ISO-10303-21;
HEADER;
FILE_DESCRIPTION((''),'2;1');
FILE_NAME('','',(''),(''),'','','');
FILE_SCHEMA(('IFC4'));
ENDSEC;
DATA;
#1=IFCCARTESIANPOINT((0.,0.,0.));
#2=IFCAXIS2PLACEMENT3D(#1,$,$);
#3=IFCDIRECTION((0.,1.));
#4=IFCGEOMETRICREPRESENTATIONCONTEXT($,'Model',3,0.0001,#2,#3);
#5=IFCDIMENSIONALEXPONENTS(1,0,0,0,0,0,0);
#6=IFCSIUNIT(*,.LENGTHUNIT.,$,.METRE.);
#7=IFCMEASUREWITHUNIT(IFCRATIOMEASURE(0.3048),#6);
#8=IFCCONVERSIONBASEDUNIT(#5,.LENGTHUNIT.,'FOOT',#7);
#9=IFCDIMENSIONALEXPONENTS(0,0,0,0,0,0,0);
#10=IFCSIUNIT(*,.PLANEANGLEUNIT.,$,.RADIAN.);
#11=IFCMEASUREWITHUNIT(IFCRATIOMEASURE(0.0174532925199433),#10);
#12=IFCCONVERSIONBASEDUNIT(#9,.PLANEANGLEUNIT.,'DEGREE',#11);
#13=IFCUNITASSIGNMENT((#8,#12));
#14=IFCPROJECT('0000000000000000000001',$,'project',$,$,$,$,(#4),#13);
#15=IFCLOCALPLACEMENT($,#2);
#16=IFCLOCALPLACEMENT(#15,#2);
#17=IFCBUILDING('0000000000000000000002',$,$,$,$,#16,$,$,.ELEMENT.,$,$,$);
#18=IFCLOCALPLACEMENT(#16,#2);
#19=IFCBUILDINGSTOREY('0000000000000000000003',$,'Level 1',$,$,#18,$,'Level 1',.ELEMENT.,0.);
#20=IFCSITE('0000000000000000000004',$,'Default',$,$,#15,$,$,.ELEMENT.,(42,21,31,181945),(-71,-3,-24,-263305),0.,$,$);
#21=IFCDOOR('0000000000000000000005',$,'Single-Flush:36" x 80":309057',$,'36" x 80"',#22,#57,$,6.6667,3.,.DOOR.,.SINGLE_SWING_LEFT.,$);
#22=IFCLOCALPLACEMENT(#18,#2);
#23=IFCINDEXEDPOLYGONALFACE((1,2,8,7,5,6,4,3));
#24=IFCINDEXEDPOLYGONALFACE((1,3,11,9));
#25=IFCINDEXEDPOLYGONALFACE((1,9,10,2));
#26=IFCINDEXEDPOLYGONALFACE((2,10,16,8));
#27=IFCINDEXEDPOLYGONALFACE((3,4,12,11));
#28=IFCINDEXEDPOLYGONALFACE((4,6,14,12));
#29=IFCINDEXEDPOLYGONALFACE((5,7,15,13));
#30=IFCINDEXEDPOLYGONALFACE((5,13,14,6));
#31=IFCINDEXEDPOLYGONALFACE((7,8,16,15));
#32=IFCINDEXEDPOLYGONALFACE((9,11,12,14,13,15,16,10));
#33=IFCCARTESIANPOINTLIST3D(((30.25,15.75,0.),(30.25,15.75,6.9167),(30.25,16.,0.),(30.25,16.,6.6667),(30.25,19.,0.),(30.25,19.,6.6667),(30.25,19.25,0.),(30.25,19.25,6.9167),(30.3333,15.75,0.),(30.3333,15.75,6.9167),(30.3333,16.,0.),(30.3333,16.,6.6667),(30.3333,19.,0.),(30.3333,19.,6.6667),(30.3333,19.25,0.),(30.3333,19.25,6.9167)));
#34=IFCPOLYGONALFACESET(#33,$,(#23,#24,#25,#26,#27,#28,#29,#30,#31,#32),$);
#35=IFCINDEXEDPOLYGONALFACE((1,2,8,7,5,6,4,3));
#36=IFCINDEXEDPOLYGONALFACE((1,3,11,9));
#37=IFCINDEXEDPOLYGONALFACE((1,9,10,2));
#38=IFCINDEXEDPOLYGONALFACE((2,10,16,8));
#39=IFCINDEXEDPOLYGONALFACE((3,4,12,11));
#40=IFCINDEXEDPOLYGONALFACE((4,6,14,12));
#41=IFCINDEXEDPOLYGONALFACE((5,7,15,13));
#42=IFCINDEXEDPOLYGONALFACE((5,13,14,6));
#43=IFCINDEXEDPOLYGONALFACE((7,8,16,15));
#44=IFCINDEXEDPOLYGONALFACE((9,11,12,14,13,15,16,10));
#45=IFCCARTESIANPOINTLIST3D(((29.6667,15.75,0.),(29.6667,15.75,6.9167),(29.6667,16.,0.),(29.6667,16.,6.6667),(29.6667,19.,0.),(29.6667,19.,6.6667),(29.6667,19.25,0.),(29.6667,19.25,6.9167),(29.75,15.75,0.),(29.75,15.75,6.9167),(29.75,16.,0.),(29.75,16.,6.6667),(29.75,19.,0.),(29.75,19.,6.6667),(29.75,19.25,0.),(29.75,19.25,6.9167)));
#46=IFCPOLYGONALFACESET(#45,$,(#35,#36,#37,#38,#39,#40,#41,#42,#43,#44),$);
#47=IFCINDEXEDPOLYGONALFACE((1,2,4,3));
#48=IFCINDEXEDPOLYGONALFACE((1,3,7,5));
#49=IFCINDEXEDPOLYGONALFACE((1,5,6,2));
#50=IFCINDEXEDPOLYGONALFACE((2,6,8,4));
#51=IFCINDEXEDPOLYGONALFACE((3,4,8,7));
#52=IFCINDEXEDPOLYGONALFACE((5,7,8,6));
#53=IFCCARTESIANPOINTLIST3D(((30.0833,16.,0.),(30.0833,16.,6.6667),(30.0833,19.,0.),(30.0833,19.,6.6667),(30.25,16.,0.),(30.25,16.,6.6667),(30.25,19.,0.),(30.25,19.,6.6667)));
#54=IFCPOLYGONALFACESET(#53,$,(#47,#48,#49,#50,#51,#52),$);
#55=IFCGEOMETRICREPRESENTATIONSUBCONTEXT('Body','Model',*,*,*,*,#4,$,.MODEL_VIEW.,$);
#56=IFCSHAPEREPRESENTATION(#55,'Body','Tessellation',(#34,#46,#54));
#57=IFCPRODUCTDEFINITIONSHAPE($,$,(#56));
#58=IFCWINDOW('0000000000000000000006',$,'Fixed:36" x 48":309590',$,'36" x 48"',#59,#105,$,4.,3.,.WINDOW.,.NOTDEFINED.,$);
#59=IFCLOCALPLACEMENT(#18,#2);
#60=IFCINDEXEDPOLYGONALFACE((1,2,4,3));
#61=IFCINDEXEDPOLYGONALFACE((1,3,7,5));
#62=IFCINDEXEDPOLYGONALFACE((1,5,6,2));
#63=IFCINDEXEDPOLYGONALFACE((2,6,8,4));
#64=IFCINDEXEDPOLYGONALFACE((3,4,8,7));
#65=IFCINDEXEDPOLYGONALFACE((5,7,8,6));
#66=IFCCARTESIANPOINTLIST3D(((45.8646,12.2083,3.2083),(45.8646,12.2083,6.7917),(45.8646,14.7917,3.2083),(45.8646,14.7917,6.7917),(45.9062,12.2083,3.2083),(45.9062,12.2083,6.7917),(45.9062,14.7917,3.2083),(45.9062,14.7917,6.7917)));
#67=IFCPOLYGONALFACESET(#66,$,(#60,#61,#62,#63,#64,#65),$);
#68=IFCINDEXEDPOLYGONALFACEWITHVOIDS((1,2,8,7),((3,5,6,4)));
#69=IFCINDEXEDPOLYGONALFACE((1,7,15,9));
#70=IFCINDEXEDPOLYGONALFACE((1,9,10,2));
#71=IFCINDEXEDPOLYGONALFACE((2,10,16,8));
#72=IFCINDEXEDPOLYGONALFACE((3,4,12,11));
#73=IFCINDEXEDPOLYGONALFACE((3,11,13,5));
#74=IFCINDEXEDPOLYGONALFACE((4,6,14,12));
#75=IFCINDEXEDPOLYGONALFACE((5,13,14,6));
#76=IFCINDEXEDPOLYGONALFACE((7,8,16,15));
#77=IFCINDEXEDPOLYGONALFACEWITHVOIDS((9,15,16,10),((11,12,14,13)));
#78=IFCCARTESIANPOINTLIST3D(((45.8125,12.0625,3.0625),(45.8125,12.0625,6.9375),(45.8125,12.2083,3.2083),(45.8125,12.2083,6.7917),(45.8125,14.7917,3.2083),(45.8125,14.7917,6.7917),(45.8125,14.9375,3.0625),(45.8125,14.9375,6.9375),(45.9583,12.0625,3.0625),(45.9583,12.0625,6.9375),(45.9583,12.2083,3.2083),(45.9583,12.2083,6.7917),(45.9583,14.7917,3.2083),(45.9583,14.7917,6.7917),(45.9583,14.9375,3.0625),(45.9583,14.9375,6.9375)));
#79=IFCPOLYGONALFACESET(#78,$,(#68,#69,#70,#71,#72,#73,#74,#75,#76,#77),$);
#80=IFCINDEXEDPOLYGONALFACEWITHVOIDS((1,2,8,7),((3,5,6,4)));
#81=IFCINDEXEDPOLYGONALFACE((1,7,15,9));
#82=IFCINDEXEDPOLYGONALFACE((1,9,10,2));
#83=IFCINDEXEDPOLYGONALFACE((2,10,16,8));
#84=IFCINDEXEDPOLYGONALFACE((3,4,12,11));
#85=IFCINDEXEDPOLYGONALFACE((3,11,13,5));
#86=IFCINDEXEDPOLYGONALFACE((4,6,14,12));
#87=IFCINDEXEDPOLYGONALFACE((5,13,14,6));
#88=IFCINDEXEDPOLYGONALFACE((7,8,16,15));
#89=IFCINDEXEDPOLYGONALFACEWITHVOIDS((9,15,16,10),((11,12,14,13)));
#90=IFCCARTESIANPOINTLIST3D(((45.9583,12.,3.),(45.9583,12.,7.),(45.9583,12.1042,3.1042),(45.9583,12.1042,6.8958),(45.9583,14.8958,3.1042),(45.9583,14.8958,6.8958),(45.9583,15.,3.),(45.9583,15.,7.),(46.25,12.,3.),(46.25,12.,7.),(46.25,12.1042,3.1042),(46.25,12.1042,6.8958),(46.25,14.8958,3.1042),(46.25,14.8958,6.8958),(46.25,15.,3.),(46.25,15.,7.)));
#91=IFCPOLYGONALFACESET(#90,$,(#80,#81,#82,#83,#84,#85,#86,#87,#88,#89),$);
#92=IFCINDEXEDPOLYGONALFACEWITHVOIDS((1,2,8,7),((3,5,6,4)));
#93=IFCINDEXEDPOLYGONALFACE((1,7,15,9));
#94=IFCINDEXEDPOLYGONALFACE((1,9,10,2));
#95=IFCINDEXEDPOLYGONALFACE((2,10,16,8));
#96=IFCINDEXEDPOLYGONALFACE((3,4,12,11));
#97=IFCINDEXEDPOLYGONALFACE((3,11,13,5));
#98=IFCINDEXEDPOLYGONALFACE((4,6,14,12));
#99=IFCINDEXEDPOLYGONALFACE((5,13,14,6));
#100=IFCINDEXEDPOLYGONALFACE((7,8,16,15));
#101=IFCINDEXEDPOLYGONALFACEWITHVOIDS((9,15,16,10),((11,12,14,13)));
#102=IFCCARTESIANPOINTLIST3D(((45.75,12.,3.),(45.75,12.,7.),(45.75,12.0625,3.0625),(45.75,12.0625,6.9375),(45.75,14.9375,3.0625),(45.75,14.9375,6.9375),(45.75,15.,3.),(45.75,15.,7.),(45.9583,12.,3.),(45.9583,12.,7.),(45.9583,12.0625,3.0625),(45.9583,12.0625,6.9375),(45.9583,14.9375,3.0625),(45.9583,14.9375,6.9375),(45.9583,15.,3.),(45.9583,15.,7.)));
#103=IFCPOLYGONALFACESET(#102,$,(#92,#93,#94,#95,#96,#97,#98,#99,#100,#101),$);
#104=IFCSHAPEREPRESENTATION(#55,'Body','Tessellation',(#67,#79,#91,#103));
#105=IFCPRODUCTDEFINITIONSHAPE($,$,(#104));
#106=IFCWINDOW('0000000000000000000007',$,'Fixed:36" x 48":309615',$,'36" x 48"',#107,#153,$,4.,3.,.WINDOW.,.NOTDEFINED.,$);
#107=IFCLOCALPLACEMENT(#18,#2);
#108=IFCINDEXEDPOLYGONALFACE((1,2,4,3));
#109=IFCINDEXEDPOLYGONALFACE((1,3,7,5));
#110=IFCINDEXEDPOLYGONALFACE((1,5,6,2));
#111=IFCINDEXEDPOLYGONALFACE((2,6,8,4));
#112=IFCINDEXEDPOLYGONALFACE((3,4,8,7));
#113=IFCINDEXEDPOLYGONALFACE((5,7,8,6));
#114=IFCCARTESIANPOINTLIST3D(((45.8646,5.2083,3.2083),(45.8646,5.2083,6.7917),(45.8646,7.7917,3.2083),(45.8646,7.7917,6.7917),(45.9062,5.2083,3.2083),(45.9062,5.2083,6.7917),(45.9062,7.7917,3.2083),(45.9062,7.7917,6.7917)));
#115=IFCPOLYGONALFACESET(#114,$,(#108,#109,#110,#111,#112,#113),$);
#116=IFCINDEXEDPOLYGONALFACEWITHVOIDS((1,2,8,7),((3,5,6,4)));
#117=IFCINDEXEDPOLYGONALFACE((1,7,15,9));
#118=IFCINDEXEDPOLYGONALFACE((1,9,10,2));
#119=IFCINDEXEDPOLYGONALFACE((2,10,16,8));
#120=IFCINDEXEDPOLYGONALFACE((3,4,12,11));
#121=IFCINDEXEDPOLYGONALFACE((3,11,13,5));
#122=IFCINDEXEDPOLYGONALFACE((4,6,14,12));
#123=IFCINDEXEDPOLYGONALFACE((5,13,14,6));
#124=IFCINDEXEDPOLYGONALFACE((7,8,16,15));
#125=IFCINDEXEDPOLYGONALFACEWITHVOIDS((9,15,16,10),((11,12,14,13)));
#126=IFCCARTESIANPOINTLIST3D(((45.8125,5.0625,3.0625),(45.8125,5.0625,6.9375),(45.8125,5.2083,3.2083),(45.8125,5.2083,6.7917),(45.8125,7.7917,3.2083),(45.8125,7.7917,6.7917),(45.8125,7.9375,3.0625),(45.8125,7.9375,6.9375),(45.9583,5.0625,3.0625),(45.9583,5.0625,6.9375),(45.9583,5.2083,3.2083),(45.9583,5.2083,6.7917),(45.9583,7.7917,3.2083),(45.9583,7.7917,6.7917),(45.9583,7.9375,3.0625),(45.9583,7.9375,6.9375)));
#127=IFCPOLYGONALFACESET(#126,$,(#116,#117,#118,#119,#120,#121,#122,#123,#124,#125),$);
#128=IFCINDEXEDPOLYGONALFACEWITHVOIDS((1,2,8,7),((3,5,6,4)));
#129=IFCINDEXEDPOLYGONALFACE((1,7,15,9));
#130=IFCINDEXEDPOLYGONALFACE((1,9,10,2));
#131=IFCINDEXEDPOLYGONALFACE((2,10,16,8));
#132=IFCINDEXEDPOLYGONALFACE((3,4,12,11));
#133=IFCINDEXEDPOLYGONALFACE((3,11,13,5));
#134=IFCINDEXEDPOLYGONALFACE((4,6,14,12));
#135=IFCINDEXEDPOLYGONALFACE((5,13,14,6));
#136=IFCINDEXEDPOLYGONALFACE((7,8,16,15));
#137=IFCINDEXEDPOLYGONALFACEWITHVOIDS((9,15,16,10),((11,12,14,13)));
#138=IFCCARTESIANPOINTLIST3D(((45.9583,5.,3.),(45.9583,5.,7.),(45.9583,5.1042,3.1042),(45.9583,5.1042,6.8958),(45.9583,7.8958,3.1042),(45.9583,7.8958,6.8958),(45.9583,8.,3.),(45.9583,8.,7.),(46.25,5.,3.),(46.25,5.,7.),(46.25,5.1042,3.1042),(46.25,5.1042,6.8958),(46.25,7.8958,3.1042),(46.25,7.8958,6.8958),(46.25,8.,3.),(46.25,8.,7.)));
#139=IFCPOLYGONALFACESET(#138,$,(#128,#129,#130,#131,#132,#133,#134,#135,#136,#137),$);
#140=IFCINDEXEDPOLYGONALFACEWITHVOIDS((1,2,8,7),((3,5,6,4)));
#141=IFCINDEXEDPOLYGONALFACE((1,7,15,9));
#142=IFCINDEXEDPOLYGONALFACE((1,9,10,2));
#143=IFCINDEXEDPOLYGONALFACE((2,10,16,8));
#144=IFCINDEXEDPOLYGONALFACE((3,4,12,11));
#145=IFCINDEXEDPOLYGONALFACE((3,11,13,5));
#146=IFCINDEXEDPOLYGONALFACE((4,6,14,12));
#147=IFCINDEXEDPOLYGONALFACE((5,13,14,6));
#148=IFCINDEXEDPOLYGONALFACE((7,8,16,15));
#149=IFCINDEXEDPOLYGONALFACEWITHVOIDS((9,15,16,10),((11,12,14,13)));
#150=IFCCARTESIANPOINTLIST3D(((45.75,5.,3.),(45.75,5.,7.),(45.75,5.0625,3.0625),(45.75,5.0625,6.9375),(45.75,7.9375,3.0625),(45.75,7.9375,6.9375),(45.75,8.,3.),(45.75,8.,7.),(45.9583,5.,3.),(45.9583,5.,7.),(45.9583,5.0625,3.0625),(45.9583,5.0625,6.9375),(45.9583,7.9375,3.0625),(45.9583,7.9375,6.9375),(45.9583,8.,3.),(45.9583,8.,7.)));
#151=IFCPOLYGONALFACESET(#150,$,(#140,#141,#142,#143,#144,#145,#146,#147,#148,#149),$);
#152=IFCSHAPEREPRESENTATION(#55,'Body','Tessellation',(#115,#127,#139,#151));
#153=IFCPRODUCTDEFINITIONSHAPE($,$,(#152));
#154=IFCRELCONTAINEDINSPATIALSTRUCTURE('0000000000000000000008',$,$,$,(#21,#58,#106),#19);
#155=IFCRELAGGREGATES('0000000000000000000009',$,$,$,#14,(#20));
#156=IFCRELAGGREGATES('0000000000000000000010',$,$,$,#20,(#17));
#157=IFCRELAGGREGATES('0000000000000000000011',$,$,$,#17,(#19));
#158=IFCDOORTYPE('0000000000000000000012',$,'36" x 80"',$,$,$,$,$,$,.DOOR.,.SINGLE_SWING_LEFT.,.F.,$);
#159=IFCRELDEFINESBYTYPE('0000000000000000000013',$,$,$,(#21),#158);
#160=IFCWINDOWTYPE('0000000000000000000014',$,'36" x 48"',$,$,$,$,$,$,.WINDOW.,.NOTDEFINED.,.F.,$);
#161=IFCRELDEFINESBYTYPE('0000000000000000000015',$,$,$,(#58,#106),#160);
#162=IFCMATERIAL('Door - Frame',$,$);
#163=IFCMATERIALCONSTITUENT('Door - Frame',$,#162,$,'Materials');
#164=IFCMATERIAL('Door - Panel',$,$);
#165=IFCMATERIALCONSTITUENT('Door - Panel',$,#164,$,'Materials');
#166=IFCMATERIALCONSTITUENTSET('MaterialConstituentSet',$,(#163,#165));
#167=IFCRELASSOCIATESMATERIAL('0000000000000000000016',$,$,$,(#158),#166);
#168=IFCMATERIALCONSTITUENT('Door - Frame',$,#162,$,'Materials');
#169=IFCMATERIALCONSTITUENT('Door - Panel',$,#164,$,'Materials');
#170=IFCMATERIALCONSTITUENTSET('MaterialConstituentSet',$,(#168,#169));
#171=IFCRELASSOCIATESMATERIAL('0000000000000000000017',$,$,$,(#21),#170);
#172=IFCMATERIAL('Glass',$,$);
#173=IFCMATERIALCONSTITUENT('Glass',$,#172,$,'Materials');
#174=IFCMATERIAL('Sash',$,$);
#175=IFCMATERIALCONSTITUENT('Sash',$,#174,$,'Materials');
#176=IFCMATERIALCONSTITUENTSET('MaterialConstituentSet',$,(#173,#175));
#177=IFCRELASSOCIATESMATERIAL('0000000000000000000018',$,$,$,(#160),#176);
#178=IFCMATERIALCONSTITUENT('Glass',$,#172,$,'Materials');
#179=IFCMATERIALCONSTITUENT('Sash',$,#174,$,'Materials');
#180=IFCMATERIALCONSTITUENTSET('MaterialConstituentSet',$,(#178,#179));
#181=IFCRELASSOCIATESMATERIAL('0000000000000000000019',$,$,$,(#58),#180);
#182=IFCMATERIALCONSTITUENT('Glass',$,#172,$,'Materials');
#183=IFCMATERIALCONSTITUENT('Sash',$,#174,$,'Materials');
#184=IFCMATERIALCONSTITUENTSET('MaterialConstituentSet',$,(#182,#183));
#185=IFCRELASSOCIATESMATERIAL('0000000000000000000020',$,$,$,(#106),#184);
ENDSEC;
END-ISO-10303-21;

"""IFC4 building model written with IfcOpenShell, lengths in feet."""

from ifc_helpers import new_model, entity, si_unit, converted_unit, direction, frame, frame_2d, origin, origin_2d_with_axis, place, context, subcontext, project, spatial, polyline, rectangle, outline, extrude, source, transform, mapped, material, constituent, constituent_set, type_object, type_shapes, element, save


model = new_model("IFC4")

# Units and contexts
model_context = context("Model", 3, precision=0.0001, world=origin(), true_north=direction((0.0, 1.0)))
body_context = subcontext(model_context, "Body", "Model", "MODEL_VIEW")
ifc_project = project(units=[converted_unit("LENGTHUNIT", "FOOT", entity("IfcRatioMeasure", 0.3048), si_unit("LENGTHUNIT", "METRE"), dimensions=[1, 0, 0, 0, 0, 0, 0]), converted_unit("PLANEANGLEUNIT", "DEGREE", entity("IfcRatioMeasure", 0.0174532925199433), si_unit("PLANEANGLEUNIT", "RADIAN"), dimensions=[0, 0, 0, 0, 0, 0, 0])], contexts=[model_context])

# Site, building, storey
site_placement = place(None, origin())
site = spatial("IfcSite", under=ifc_project, at=site_placement, Name="Default", CompositionType="ELEMENT", RefLatitude=(42, 21, 31, 181945), RefLongitude=(-71, -3, -24, -263305), RefElevation=0.0)
building_placement = place(site_placement, origin())
building = spatial("IfcBuilding", under=site, at=building_placement, CompositionType="ELEMENT")
storey_placement = place(building_placement, origin())
storey = spatial("IfcBuildingStorey", under=building, at=storey_placement, Name="Level 1", LongName="Level 1", CompositionType="ELEMENT", Elevation=0.0)

# Door
ifc_material_1 = material(Name="Door - Frame")
ifc_material_2 = material(Name="Door - Panel")
ifc_constituent_1 = constituent(ifc_material_1, Name="Door - Frame", Category="Materials")
ifc_constituent_2 = constituent(ifc_material_2, Name="Door - Panel", Category="Materials")
ifc_constituent_set_1 = constituent_set(constituents=[ifc_constituent_1, ifc_constituent_2], Name="MaterialConstituentSet")
ifc_constituent_3 = constituent(ifc_material_1, Name="Door - Frame", Category="Materials")
ifc_constituent_4 = constituent(ifc_material_2, Name="Door - Panel", Category="Materials")
ifc_constituent_set_2 = constituent_set(constituents=[ifc_constituent_3, ifc_constituent_4], Name="MaterialConstituentSet")
door_type_1 = type_object("IfcDoorType", Name="36\" x 80\"", OperationType="SINGLE_SWING_LEFT", ParameterTakesPrecedence=False, PredefinedType="DOOR", material=ifc_constituent_set_2)
shared_shape_1 = source(origin(), body_context, "Body", "SweptSolid", [
    extrude(outline(polyline([(-1.75, -3.5208), (1.75, -3.5208), (1.75, 3.3958), (1.5, 3.3958), (1.5, -3.2708), (-1.5, -3.2708), (-1.5, 3.3958), (-1.75, 3.3958), (-1.75, -3.5208)])), frame((1.5, 0.5833, 3.3958), z_axis=(0.0, -1.0, 0.0), x_axis=(-1.0, 0.0, 0.0)), (0.0, 0.0, 1.0), 0.0833),
    extrude(outline(polyline([(-3.5208, -1.75), (3.3958, -1.75), (3.3958, -1.5), (-3.2708, -1.5), (-3.2708, 1.5), (3.3958, 1.5), (3.3958, 1.75), (-3.5208, 1.75), (-3.5208, -1.75)])), frame((1.5, 0.0, 3.3958), z_axis=(0.0, -1.0, 0.0), x_axis=(0.0, 0.0, -1.0)), (0.0, 0.0, 1.0), 0.0833),
    extrude(rectangle(XDim=3.0, YDim=0.1667, at=origin_2d_with_axis()), frame((1.5, 0.4167, 0.0)), (0.0, 0.0, 1.0), 6.6667),
])
type_shapes(door_type_1, [shared_shape_1])
placement_1 = place(storey_placement, frame((30.0, 45.75, 0.0), z_axis=(0.0, 0.0, 1.0), x_axis=(0.0, -1.0, 0.0)))
placement_2 = place(placement_1, frame((26.75, -0.25, 0.0)))
door_1_placement = place(placement_2, origin())
element("IfcDoor", 1, at=door_1_placement, inside=storey, type_object=door_type_1, material=ifc_constituent_set_1, Name="Single-Flush:36\" x 80\":309057", ObjectType="36\" x 80\"", OperationType="SINGLE_SWING_LEFT", OverallHeight=6.6667, OverallWidth=3.0, PredefinedType="DOOR", context=body_context, shape_type="MappedRepresentation", body=[
    mapped(shared_shape_1, transform((0.0, 0.0, 0.0), scale=1.0)),
])

# Windows
ifc_material_3 = material(Name="Glass")
ifc_constituent_5 = constituent(ifc_material_3, Name="Glass", Category="Materials")
ifc_material_4 = material(Name="Sash")
ifc_constituent_6 = constituent(ifc_material_4, Name="Sash", Category="Materials")
ifc_constituent_set_3 = constituent_set(constituents=[ifc_constituent_5, ifc_constituent_6], Name="MaterialConstituentSet")
ifc_constituent_7 = constituent(ifc_material_3, Name="Glass", Category="Materials")
ifc_constituent_8 = constituent(ifc_material_4, Name="Sash", Category="Materials")
ifc_constituent_set_4 = constituent_set(constituents=[ifc_constituent_7, ifc_constituent_8], Name="MaterialConstituentSet")
window_type = type_object("IfcWindowType", Name="36\" x 48\"", ParameterTakesPrecedence=False, PartitioningType="NOTDEFINED", PredefinedType="WINDOW", material=ifc_constituent_set_4)
shared_shape_2 = source(origin(), body_context, "Body", "SweptSolid", [
    extrude(rectangle(XDim=0.0417, YDim=2.5833, at=frame_2d((0.0, 0.0), x_axis=(1.0, 0.0))), frame((1.5, 0.3646, 0.2083), z_axis=(0.0, 0.0, 1.0), x_axis=(0.0, 1.0, 0.0)), (0.0, 0.0, 1.0), 3.5833),
    extrude(outline(polyline([(-1.4375, -1.9375), (1.4375, -1.9375), (1.4375, 1.9375), (-1.4375, 1.9375), (-1.4375, -1.9375)]), holes=[polyline([(-1.2917, -1.7917), (-1.2917, 1.7917), (1.2917, 1.7917), (1.2917, -1.7917), (-1.2917, -1.7917)])]), frame((1.5, 0.2917, 2.0), z_axis=(0.0, 1.0, 0.0), x_axis=(1.0, 0.0, 0.0)), (0.0, 0.0, 1.0), 0.1458),
    extrude(outline(polyline([(-1.5, -2.0), (1.5, -2.0), (1.5, 2.0), (-1.5, 2.0), (-1.5, -2.0)]), holes=[polyline([(-1.3958, -1.8958), (-1.3958, 1.8958), (1.3958, 1.8958), (1.3958, -1.8958), (-1.3958, -1.8958)])]), frame((1.5, 0.0, 2.0), z_axis=(0.0, 1.0, 0.0), x_axis=(1.0, 0.0, 0.0)), (0.0, 0.0, 1.0), 0.2917),
    extrude(outline(polyline([(-2.0, -1.5), (2.0, -1.5), (2.0, 1.5), (-2.0, 1.5), (-2.0, -1.5)]), holes=[polyline([(-1.9375, -1.4375), (-1.9375, 1.4375), (1.9375, 1.4375), (1.9375, -1.4375), (-1.9375, -1.4375)])]), frame((1.5, 0.2917, 2.0), z_axis=(0.0, 1.0, 0.0), x_axis=(0.0, 0.0, -1.0)), (0.0, 0.0, 1.0), 0.2083),
])
type_shapes(window_type, [shared_shape_2])
placement_3 = place(storey_placement, frame((46.0, 46.25, 0.0), z_axis=(0.0, 0.0, 1.0), x_axis=(0.0, -1.0, 0.0)))
placement_4 = place(placement_3, frame((34.25, 0.25, 3.0)))
window_1_placement = place(placement_4, frame((0.0, 0.0, 0.0), z_axis=(0.0, 0.0, 1.0), x_axis=(-1.0, 0.0, 0.0)))
element("IfcWindow", 2, at=window_1_placement, inside=storey, type_object=window_type, material=ifc_constituent_set_3, Name="Fixed:36\" x 48\":309590", ObjectType="36\" x 48\"", OverallHeight=4.0, OverallWidth=3.0, PartitioningType="NOTDEFINED", PredefinedType="WINDOW", context=body_context, shape_type="MappedRepresentation", body=[
    mapped(shared_shape_2, transform((0.0, 0.0, 0.0), scale=1.0)),
])
ifc_constituent_9 = constituent(ifc_material_3, Name="Glass", Category="Materials")
ifc_constituent_10 = constituent(ifc_material_4, Name="Sash", Category="Materials")
ifc_constituent_set_5 = constituent_set(constituents=[ifc_constituent_9, ifc_constituent_10], Name="MaterialConstituentSet")
placement_5 = place(placement_3, frame((41.25, 0.25, 3.0)))
window_2_placement = place(placement_5, frame((0.0, 0.0, 0.0), z_axis=(0.0, 0.0, 1.0), x_axis=(-1.0, 0.0, 0.0)))
element("IfcWindow", 3, at=window_2_placement, inside=storey, type_object=window_type, material=ifc_constituent_set_5, Name="Fixed:36\" x 48\":309615", ObjectType="36\" x 48\"", OverallHeight=4.0, OverallWidth=3.0, PartitioningType="NOTDEFINED", PredefinedType="WINDOW", context=body_context, shape_type="MappedRepresentation", body=[
    mapped(shared_shape_2, transform((0.0, 0.0, 0.0), scale=1.0)),
])

save(model, "model.ifc")
